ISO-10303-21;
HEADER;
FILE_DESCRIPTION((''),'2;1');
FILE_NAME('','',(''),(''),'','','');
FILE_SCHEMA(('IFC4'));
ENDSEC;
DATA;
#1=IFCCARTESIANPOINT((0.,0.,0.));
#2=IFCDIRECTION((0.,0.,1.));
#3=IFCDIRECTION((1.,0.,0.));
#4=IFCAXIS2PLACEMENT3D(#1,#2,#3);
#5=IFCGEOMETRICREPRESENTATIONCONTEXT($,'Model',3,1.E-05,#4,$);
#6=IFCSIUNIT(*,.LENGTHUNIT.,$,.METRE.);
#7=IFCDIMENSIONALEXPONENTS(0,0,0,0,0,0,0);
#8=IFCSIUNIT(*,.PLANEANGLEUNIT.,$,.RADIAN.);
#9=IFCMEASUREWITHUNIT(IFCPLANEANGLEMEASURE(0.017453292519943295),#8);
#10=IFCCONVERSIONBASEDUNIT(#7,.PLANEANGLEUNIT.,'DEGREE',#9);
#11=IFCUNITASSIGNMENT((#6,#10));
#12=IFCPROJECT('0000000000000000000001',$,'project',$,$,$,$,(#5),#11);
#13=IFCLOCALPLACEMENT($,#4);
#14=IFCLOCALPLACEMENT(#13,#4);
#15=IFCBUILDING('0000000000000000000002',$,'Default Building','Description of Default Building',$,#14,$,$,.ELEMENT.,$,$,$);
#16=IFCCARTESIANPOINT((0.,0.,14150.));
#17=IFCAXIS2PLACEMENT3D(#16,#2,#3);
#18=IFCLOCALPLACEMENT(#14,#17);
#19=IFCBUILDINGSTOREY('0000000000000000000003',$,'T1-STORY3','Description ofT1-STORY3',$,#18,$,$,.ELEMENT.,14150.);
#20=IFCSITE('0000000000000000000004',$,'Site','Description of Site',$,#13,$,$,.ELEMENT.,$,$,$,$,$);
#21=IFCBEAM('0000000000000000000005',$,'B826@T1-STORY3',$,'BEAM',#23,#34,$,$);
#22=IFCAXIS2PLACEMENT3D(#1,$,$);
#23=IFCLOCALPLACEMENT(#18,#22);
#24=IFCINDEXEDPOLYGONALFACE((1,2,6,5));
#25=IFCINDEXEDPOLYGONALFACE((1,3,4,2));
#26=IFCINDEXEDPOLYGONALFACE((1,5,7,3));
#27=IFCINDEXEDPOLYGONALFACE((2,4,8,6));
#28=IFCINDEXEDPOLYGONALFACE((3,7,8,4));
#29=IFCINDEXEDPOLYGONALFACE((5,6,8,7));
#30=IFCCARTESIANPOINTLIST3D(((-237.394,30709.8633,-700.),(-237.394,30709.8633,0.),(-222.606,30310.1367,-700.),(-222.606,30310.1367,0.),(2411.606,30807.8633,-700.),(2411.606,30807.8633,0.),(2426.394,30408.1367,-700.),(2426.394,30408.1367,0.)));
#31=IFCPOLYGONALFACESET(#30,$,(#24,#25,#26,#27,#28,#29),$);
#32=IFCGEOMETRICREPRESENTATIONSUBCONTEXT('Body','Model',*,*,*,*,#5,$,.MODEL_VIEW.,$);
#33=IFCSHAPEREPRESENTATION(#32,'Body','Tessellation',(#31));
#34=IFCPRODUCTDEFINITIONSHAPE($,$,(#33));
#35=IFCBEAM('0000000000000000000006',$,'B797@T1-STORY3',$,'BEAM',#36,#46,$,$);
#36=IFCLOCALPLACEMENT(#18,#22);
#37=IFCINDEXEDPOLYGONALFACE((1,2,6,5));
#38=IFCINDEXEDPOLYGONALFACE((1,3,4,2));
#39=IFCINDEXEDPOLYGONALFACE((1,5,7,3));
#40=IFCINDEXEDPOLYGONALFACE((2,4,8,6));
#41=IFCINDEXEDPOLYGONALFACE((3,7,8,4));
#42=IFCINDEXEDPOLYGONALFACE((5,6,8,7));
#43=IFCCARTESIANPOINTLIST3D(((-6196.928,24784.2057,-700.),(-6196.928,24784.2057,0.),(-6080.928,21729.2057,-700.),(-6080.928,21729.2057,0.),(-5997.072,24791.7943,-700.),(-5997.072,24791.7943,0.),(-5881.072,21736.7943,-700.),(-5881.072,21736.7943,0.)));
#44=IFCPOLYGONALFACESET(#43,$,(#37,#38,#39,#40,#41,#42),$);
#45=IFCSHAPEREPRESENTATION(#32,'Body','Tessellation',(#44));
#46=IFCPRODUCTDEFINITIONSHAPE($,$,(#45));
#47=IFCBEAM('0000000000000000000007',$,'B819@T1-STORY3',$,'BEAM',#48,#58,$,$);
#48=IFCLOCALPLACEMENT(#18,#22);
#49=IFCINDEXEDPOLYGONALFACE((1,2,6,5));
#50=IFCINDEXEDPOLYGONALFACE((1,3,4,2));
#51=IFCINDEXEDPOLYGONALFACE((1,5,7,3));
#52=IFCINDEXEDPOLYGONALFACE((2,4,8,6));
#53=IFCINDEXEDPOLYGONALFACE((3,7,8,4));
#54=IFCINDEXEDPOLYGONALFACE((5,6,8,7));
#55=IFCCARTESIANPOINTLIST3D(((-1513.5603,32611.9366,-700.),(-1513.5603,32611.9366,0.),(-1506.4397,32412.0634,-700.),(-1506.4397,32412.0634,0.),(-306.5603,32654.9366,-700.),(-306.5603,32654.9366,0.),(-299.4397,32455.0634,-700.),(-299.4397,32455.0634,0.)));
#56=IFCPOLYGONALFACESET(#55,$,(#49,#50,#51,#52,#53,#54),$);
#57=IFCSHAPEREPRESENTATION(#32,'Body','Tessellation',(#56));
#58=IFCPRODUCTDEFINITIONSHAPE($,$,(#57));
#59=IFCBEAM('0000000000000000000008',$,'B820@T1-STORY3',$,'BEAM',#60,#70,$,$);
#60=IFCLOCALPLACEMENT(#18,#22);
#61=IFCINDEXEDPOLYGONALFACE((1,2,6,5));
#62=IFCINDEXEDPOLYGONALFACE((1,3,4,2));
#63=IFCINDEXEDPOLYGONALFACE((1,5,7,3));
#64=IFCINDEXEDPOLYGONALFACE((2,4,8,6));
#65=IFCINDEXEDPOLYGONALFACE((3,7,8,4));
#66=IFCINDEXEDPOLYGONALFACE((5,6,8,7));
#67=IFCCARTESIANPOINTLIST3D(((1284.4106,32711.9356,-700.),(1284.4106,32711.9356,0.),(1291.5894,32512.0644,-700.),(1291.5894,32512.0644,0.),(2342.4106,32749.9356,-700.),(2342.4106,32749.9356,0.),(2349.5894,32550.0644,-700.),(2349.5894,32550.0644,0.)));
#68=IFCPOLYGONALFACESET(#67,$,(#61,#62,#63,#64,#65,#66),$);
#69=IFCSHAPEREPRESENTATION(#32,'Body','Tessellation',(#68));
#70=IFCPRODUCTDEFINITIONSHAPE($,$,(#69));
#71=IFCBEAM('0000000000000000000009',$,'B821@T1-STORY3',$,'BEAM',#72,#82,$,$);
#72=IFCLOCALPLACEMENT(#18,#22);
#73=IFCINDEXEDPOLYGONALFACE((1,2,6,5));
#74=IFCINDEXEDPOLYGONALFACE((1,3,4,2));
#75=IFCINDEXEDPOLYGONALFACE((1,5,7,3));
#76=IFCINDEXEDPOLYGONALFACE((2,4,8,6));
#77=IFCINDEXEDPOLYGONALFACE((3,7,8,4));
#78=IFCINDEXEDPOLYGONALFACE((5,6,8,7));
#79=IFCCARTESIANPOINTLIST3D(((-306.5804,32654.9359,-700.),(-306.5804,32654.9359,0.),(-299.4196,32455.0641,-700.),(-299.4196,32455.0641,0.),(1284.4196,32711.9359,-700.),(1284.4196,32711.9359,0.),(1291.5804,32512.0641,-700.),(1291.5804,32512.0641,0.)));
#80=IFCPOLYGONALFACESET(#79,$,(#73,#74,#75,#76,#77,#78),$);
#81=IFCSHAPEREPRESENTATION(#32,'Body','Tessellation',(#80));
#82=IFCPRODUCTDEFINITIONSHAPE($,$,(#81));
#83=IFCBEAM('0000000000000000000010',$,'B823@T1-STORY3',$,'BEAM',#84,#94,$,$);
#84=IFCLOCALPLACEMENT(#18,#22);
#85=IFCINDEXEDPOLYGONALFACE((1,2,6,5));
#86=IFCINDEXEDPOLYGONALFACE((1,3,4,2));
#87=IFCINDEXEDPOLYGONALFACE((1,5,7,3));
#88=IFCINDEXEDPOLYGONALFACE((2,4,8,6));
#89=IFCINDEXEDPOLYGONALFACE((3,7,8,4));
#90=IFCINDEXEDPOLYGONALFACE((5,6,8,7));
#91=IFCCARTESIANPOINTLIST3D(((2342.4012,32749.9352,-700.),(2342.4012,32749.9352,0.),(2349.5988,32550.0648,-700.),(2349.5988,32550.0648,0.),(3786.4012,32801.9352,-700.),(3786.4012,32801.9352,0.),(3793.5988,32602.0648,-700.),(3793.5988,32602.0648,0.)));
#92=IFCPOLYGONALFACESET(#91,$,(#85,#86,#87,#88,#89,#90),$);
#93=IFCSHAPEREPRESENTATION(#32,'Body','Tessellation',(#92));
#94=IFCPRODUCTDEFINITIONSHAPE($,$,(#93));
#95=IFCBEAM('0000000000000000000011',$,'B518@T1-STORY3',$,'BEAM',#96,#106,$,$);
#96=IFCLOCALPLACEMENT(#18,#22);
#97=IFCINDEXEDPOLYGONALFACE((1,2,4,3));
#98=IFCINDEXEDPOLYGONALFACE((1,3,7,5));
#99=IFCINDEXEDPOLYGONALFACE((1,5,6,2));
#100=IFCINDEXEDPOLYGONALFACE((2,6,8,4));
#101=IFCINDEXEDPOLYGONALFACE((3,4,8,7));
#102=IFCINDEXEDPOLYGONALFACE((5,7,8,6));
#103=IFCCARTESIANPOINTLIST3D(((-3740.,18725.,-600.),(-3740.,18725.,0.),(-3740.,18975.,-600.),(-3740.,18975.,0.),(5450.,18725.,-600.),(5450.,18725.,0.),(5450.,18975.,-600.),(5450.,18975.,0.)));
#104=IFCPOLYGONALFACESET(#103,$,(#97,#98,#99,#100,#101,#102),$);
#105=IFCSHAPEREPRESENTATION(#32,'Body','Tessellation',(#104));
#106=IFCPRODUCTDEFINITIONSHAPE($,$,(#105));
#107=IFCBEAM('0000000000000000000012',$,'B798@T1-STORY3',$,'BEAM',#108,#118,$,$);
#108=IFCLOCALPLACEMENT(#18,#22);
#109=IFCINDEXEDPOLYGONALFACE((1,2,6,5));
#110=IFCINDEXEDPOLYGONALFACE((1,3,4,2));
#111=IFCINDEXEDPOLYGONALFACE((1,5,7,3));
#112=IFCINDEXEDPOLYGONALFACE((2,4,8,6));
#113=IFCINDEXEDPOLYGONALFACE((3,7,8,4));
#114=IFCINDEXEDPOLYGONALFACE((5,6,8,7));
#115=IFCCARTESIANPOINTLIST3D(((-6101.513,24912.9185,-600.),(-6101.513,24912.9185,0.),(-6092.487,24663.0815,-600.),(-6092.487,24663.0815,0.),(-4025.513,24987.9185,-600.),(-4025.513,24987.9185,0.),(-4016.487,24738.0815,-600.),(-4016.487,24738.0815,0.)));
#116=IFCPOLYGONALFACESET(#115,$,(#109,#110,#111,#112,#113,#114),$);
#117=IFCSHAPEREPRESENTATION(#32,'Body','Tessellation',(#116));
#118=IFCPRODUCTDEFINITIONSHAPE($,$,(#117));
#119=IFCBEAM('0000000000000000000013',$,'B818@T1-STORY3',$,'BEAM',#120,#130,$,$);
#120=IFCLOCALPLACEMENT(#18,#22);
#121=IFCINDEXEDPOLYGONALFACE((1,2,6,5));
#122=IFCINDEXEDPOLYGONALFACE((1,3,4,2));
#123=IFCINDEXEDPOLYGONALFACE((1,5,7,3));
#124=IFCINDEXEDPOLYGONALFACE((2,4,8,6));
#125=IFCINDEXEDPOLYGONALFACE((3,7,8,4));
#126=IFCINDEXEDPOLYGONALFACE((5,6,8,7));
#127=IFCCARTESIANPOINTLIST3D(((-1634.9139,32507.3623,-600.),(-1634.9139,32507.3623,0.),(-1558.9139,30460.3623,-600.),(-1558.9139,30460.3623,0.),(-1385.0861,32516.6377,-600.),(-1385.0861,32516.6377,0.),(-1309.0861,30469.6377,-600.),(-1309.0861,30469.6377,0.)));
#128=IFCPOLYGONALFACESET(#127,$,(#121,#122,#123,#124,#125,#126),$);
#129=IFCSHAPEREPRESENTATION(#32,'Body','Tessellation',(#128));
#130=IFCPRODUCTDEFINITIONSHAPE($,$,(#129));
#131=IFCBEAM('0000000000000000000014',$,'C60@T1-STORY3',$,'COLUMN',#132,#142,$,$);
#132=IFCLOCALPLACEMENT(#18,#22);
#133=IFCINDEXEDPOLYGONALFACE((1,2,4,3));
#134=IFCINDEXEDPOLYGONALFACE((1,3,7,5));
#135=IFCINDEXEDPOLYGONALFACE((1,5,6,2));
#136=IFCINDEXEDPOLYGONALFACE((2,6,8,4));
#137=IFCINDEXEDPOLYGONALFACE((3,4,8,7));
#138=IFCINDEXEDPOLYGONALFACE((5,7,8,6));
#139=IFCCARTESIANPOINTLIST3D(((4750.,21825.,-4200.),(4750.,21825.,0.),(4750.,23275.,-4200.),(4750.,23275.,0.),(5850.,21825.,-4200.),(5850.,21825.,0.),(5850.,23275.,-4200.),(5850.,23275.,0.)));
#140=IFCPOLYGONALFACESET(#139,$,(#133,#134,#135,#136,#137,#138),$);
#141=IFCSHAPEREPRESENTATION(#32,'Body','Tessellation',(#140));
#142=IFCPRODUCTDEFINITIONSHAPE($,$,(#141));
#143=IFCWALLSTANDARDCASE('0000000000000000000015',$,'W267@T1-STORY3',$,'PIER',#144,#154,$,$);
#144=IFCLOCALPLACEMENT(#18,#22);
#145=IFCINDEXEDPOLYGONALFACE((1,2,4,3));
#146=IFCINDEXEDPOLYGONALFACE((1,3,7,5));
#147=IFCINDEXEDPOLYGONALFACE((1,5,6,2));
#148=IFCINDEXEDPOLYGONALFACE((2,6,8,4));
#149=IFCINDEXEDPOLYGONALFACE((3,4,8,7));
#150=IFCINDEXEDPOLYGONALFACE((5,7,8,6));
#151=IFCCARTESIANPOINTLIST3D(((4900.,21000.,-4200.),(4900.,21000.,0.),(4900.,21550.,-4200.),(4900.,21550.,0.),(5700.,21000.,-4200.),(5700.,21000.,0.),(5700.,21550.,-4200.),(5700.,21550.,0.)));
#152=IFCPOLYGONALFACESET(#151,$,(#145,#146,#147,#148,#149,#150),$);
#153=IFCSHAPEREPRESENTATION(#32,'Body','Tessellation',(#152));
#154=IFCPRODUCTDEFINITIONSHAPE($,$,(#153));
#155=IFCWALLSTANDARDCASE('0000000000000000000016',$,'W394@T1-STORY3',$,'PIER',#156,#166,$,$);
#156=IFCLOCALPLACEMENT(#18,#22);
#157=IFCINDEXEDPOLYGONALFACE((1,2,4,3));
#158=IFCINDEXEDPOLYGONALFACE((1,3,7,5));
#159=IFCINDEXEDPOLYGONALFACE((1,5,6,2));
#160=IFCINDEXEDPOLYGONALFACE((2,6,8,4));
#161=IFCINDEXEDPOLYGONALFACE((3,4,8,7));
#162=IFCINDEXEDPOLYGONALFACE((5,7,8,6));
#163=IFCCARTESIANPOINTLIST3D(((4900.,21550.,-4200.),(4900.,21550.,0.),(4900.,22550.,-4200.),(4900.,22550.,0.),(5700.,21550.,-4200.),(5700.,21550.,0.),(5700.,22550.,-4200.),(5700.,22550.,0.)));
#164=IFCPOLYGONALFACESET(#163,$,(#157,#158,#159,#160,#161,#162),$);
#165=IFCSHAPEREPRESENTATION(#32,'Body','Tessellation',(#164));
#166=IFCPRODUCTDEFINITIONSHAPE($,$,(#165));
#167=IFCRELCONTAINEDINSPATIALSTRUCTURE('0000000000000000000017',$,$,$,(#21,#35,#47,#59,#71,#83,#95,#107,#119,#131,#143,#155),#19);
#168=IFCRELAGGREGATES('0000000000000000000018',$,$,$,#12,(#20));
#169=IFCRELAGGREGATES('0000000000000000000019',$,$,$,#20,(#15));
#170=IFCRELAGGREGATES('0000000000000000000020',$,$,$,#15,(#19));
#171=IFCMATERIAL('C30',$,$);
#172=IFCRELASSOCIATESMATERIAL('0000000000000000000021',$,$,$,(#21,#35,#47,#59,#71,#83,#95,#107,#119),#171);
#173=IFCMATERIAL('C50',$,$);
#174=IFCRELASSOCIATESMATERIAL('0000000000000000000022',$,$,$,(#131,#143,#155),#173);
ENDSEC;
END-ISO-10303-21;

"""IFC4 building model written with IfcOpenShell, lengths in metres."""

from ifc_helpers import new_model, entity, si_unit, converted_unit, frame, origin_with_axes, place, context, subcontext, project, spatial, indexed_curve, rectangle, outline, extrude, material, element, save


model = new_model("IFC4")

# Units and contexts
model_context = context("Model", 3, precision=1e-05, world=origin_with_axes())
body_context = subcontext(model_context, "Body", "Model", "MODEL_VIEW")
ifc_project = project(units=[si_unit("LENGTHUNIT", "METRE"), converted_unit("PLANEANGLEUNIT", "DEGREE", entity("IfcPlaneAngleMeasure", 0.017453292519943295), si_unit("PLANEANGLEUNIT", "RADIAN"), dimensions=[0, 0, 0, 0, 0, 0, 0])], contexts=[model_context])

# Site, building, storey
site_placement = place(None, origin_with_axes())
site = spatial("IfcSite", under=ifc_project, at=site_placement, Name="Site", Description="Description of Site", CompositionType="ELEMENT")
building_placement = place(site_placement, origin_with_axes())
building = spatial("IfcBuilding", under=site, at=building_placement, Name="Default Building", Description="Description of Default Building", CompositionType="ELEMENT")
storey_placement = place(building_placement, frame((0.0, 0.0, 14150.0), z_axis=(0.0, 0.0, 1.0), x_axis=(1.0, 0.0, 0.0)))
storey = spatial("IfcBuildingStorey", under=building, at=storey_placement, Name="T1-STORY3", Description="Description ofT1-STORY3", CompositionType="ELEMENT", Elevation=14150.0)

# Beams
ifc_material_1 = material(Name="C30")
beam_1_placement = place(storey_placement, frame((-230.0, 30510.0, -350.0), z_axis=(0.999316, 0.03697, 0.0), x_axis=(-0.03697, 0.999316, 0.0)))
element("IfcBeam", 1, at=beam_1_placement, inside=storey, material=ifc_material_1, Name="B826@T1-STORY3", ObjectType="BEAM", context=body_context, shape_type="SweptSolid", body=[
    extrude(rectangle(XDim=400.0, YDim=700.0), origin_with_axes(), (0.0, 0.0, 1.0), 2650.8121),
])
beam_2_placement = place(storey_placement, frame((-6097.0, 24788.0, -350.0), z_axis=(0.037943, -0.99928, 0.0), x_axis=(0.99928, 0.037943, 0.0)))
element("IfcBeam", 2, at=beam_2_placement, inside=storey, material=ifc_material_1, Name="B797@T1-STORY3", ObjectType="BEAM", context=body_context, shape_type="SweptSolid", body=[
    extrude(rectangle(XDim=200.0, YDim=700.0), origin_with_axes(), (0.0, 0.0, 1.0), 3057.2015),
])
beam_3_placement = place(storey_placement, frame((-1510.0, 32512.0, -350.0), z_axis=(0.999366, 0.035603, 0.0), x_axis=(-0.035603, 0.999366, 0.0)))
element("IfcBeam", 3, at=beam_3_placement, inside=storey, material=ifc_material_1, Name="B819@T1-STORY3", ObjectType="BEAM", context=body_context, shape_type="SweptSolid", body=[
    extrude(rectangle(XDim=200.0, YDim=700.0), origin_with_axes(), (0.0, 0.0, 1.0), 1207.7657),
])
beam_4_placement = place(storey_placement, frame((1288.0, 32612.0, -350.0), z_axis=(0.999356, 0.035894, 0.0), x_axis=(-0.035894, 0.999356, 0.0)))
element("IfcBeam", 4, at=beam_4_placement, inside=storey, material=ifc_material_1, Name="B820@T1-STORY3", ObjectType="BEAM", context=body_context, shape_type="SweptSolid", body=[
    extrude(rectangle(XDim=200.0, YDim=700.0), origin_with_axes(), (0.0, 0.0, 1.0), 1058.6822),
])
beam_5_placement = place(storey_placement, frame((-303.0, 32555.0, -350.0), z_axis=(0.999359, 0.035804, 0.0), x_axis=(-0.035804, 0.999359, 0.0)))
element("IfcBeam", 5, at=beam_5_placement, inside=storey, material=ifc_material_1, Name="B821@T1-STORY3", ObjectType="BEAM", context=body_context, shape_type="SweptSolid", body=[
    extrude(rectangle(XDim=200.0, YDim=700.0), origin_with_axes(), (0.0, 0.0, 1.0), 1592.0207),
])
beam_6_placement = place(storey_placement, frame((2346.0, 32650.0, -350.0), z_axis=(0.999352, 0.035988, 0.0), x_axis=(-0.035988, 0.999352, 0.0)))
element("IfcBeam", 6, at=beam_6_placement, inside=storey, material=ifc_material_1, Name="B823@T1-STORY3", ObjectType="BEAM", context=body_context, shape_type="SweptSolid", body=[
    extrude(rectangle(XDim=200.0, YDim=700.0), origin_with_axes(), (0.0, 0.0, 1.0), 1444.936),
])
beam_7_placement = place(storey_placement, frame((-3740.0, 18850.0, -300.0), z_axis=(1.0, 0.0, 0.0), x_axis=(0.0, 1.0, 0.0)))
element("IfcBeam", 7, at=beam_7_placement, inside=storey, material=ifc_material_1, Name="B518@T1-STORY3", ObjectType="BEAM", context=body_context, shape_type="SweptSolid", body=[
    extrude(rectangle(XDim=250.0, YDim=600.0), origin_with_axes(), (0.0, 0.0, 1.0), 9190.0),
])
beam_8_placement = place(storey_placement, frame((-6097.0, 24788.0, -300.0), z_axis=(0.999348, 0.036104, 0.0), x_axis=(-0.036104, 0.999348, 0.0)))
element("IfcBeam", 8, at=beam_8_placement, inside=storey, material=ifc_material_1, Name="B798@T1-STORY3", ObjectType="BEAM", context=body_context, shape_type="SweptSolid", body=[
    extrude(rectangle(XDim=250.0, YDim=600.0), origin_with_axes(), (0.0, 0.0, 1.0), 2077.3543),
])
beam_9_placement = place(storey_placement, frame((-1510.0, 32512.0, -300.0), z_axis=(0.037102, -0.999311, 0.0), x_axis=(0.999311, 0.037102, 0.0)))
element("IfcBeam", 9, at=beam_9_placement, inside=storey, material=ifc_material_1, Name="B818@T1-STORY3", ObjectType="BEAM", context=body_context, shape_type="SweptSolid", body=[
    extrude(rectangle(XDim=250.0, YDim=600.0), origin_with_axes(), (0.0, 0.0, 1.0), 2048.4104),
])
ifc_material_2 = material(Name="C50")
beam_10_placement = place(storey_placement, frame((5300.0, 22550.0, -4200.0), z_axis=(0.0, 0.0, 1.0), x_axis=(-1.0, 0.0, 0.0)))
element("IfcBeam", 10, at=beam_10_placement, inside=storey, material=ifc_material_2, Name="C60@T1-STORY3", ObjectType="COLUMN", context=body_context, shape_type="SweptSolid", body=[
    extrude(rectangle(XDim=1100.0, YDim=1450.0), origin_with_axes(), (0.0, 0.0, 1.0), 4200.0),
])

# Walls
wall_1_placement = place(storey_placement, frame((5300.0, 21000.0, -4200.0), z_axis=(0.0, 0.0, 1.0), x_axis=(0.0, 1.0, 0.0)))
element("IfcWallStandardCase", 11, at=wall_1_placement, inside=storey, material=ifc_material_2, Name="W267@T1-STORY3", ObjectType="PIER", context=body_context, shape_type="SweptSolid", body=[
    extrude(outline(indexed_curve([(0.0, -400.0), (0.0, 400.0), (550.0, 400.0), (550.0, -400.0), (0.0, -400.0)], self_intersect=False)), origin_with_axes(), (0.0, 0.0, 1.0), 4200.0),
])
wall_2_placement = place(storey_placement, frame((5300.0, 21550.0, -4200.0), z_axis=(0.0, 0.0, 1.0), x_axis=(0.0, 1.0, 0.0)))
element("IfcWallStandardCase", 12, at=wall_2_placement, inside=storey, material=ifc_material_2, Name="W394@T1-STORY3", ObjectType="PIER", context=body_context, shape_type="SweptSolid", body=[
    extrude(outline(indexed_curve([(0.0, -400.0), (0.0, 400.0), (1000.0, 400.0), (1000.0, -400.0), (0.0, -400.0)], self_intersect=False)), origin_with_axes(), (0.0, 0.0, 1.0), 4200.0),
])

save(model, "model.ifc")
